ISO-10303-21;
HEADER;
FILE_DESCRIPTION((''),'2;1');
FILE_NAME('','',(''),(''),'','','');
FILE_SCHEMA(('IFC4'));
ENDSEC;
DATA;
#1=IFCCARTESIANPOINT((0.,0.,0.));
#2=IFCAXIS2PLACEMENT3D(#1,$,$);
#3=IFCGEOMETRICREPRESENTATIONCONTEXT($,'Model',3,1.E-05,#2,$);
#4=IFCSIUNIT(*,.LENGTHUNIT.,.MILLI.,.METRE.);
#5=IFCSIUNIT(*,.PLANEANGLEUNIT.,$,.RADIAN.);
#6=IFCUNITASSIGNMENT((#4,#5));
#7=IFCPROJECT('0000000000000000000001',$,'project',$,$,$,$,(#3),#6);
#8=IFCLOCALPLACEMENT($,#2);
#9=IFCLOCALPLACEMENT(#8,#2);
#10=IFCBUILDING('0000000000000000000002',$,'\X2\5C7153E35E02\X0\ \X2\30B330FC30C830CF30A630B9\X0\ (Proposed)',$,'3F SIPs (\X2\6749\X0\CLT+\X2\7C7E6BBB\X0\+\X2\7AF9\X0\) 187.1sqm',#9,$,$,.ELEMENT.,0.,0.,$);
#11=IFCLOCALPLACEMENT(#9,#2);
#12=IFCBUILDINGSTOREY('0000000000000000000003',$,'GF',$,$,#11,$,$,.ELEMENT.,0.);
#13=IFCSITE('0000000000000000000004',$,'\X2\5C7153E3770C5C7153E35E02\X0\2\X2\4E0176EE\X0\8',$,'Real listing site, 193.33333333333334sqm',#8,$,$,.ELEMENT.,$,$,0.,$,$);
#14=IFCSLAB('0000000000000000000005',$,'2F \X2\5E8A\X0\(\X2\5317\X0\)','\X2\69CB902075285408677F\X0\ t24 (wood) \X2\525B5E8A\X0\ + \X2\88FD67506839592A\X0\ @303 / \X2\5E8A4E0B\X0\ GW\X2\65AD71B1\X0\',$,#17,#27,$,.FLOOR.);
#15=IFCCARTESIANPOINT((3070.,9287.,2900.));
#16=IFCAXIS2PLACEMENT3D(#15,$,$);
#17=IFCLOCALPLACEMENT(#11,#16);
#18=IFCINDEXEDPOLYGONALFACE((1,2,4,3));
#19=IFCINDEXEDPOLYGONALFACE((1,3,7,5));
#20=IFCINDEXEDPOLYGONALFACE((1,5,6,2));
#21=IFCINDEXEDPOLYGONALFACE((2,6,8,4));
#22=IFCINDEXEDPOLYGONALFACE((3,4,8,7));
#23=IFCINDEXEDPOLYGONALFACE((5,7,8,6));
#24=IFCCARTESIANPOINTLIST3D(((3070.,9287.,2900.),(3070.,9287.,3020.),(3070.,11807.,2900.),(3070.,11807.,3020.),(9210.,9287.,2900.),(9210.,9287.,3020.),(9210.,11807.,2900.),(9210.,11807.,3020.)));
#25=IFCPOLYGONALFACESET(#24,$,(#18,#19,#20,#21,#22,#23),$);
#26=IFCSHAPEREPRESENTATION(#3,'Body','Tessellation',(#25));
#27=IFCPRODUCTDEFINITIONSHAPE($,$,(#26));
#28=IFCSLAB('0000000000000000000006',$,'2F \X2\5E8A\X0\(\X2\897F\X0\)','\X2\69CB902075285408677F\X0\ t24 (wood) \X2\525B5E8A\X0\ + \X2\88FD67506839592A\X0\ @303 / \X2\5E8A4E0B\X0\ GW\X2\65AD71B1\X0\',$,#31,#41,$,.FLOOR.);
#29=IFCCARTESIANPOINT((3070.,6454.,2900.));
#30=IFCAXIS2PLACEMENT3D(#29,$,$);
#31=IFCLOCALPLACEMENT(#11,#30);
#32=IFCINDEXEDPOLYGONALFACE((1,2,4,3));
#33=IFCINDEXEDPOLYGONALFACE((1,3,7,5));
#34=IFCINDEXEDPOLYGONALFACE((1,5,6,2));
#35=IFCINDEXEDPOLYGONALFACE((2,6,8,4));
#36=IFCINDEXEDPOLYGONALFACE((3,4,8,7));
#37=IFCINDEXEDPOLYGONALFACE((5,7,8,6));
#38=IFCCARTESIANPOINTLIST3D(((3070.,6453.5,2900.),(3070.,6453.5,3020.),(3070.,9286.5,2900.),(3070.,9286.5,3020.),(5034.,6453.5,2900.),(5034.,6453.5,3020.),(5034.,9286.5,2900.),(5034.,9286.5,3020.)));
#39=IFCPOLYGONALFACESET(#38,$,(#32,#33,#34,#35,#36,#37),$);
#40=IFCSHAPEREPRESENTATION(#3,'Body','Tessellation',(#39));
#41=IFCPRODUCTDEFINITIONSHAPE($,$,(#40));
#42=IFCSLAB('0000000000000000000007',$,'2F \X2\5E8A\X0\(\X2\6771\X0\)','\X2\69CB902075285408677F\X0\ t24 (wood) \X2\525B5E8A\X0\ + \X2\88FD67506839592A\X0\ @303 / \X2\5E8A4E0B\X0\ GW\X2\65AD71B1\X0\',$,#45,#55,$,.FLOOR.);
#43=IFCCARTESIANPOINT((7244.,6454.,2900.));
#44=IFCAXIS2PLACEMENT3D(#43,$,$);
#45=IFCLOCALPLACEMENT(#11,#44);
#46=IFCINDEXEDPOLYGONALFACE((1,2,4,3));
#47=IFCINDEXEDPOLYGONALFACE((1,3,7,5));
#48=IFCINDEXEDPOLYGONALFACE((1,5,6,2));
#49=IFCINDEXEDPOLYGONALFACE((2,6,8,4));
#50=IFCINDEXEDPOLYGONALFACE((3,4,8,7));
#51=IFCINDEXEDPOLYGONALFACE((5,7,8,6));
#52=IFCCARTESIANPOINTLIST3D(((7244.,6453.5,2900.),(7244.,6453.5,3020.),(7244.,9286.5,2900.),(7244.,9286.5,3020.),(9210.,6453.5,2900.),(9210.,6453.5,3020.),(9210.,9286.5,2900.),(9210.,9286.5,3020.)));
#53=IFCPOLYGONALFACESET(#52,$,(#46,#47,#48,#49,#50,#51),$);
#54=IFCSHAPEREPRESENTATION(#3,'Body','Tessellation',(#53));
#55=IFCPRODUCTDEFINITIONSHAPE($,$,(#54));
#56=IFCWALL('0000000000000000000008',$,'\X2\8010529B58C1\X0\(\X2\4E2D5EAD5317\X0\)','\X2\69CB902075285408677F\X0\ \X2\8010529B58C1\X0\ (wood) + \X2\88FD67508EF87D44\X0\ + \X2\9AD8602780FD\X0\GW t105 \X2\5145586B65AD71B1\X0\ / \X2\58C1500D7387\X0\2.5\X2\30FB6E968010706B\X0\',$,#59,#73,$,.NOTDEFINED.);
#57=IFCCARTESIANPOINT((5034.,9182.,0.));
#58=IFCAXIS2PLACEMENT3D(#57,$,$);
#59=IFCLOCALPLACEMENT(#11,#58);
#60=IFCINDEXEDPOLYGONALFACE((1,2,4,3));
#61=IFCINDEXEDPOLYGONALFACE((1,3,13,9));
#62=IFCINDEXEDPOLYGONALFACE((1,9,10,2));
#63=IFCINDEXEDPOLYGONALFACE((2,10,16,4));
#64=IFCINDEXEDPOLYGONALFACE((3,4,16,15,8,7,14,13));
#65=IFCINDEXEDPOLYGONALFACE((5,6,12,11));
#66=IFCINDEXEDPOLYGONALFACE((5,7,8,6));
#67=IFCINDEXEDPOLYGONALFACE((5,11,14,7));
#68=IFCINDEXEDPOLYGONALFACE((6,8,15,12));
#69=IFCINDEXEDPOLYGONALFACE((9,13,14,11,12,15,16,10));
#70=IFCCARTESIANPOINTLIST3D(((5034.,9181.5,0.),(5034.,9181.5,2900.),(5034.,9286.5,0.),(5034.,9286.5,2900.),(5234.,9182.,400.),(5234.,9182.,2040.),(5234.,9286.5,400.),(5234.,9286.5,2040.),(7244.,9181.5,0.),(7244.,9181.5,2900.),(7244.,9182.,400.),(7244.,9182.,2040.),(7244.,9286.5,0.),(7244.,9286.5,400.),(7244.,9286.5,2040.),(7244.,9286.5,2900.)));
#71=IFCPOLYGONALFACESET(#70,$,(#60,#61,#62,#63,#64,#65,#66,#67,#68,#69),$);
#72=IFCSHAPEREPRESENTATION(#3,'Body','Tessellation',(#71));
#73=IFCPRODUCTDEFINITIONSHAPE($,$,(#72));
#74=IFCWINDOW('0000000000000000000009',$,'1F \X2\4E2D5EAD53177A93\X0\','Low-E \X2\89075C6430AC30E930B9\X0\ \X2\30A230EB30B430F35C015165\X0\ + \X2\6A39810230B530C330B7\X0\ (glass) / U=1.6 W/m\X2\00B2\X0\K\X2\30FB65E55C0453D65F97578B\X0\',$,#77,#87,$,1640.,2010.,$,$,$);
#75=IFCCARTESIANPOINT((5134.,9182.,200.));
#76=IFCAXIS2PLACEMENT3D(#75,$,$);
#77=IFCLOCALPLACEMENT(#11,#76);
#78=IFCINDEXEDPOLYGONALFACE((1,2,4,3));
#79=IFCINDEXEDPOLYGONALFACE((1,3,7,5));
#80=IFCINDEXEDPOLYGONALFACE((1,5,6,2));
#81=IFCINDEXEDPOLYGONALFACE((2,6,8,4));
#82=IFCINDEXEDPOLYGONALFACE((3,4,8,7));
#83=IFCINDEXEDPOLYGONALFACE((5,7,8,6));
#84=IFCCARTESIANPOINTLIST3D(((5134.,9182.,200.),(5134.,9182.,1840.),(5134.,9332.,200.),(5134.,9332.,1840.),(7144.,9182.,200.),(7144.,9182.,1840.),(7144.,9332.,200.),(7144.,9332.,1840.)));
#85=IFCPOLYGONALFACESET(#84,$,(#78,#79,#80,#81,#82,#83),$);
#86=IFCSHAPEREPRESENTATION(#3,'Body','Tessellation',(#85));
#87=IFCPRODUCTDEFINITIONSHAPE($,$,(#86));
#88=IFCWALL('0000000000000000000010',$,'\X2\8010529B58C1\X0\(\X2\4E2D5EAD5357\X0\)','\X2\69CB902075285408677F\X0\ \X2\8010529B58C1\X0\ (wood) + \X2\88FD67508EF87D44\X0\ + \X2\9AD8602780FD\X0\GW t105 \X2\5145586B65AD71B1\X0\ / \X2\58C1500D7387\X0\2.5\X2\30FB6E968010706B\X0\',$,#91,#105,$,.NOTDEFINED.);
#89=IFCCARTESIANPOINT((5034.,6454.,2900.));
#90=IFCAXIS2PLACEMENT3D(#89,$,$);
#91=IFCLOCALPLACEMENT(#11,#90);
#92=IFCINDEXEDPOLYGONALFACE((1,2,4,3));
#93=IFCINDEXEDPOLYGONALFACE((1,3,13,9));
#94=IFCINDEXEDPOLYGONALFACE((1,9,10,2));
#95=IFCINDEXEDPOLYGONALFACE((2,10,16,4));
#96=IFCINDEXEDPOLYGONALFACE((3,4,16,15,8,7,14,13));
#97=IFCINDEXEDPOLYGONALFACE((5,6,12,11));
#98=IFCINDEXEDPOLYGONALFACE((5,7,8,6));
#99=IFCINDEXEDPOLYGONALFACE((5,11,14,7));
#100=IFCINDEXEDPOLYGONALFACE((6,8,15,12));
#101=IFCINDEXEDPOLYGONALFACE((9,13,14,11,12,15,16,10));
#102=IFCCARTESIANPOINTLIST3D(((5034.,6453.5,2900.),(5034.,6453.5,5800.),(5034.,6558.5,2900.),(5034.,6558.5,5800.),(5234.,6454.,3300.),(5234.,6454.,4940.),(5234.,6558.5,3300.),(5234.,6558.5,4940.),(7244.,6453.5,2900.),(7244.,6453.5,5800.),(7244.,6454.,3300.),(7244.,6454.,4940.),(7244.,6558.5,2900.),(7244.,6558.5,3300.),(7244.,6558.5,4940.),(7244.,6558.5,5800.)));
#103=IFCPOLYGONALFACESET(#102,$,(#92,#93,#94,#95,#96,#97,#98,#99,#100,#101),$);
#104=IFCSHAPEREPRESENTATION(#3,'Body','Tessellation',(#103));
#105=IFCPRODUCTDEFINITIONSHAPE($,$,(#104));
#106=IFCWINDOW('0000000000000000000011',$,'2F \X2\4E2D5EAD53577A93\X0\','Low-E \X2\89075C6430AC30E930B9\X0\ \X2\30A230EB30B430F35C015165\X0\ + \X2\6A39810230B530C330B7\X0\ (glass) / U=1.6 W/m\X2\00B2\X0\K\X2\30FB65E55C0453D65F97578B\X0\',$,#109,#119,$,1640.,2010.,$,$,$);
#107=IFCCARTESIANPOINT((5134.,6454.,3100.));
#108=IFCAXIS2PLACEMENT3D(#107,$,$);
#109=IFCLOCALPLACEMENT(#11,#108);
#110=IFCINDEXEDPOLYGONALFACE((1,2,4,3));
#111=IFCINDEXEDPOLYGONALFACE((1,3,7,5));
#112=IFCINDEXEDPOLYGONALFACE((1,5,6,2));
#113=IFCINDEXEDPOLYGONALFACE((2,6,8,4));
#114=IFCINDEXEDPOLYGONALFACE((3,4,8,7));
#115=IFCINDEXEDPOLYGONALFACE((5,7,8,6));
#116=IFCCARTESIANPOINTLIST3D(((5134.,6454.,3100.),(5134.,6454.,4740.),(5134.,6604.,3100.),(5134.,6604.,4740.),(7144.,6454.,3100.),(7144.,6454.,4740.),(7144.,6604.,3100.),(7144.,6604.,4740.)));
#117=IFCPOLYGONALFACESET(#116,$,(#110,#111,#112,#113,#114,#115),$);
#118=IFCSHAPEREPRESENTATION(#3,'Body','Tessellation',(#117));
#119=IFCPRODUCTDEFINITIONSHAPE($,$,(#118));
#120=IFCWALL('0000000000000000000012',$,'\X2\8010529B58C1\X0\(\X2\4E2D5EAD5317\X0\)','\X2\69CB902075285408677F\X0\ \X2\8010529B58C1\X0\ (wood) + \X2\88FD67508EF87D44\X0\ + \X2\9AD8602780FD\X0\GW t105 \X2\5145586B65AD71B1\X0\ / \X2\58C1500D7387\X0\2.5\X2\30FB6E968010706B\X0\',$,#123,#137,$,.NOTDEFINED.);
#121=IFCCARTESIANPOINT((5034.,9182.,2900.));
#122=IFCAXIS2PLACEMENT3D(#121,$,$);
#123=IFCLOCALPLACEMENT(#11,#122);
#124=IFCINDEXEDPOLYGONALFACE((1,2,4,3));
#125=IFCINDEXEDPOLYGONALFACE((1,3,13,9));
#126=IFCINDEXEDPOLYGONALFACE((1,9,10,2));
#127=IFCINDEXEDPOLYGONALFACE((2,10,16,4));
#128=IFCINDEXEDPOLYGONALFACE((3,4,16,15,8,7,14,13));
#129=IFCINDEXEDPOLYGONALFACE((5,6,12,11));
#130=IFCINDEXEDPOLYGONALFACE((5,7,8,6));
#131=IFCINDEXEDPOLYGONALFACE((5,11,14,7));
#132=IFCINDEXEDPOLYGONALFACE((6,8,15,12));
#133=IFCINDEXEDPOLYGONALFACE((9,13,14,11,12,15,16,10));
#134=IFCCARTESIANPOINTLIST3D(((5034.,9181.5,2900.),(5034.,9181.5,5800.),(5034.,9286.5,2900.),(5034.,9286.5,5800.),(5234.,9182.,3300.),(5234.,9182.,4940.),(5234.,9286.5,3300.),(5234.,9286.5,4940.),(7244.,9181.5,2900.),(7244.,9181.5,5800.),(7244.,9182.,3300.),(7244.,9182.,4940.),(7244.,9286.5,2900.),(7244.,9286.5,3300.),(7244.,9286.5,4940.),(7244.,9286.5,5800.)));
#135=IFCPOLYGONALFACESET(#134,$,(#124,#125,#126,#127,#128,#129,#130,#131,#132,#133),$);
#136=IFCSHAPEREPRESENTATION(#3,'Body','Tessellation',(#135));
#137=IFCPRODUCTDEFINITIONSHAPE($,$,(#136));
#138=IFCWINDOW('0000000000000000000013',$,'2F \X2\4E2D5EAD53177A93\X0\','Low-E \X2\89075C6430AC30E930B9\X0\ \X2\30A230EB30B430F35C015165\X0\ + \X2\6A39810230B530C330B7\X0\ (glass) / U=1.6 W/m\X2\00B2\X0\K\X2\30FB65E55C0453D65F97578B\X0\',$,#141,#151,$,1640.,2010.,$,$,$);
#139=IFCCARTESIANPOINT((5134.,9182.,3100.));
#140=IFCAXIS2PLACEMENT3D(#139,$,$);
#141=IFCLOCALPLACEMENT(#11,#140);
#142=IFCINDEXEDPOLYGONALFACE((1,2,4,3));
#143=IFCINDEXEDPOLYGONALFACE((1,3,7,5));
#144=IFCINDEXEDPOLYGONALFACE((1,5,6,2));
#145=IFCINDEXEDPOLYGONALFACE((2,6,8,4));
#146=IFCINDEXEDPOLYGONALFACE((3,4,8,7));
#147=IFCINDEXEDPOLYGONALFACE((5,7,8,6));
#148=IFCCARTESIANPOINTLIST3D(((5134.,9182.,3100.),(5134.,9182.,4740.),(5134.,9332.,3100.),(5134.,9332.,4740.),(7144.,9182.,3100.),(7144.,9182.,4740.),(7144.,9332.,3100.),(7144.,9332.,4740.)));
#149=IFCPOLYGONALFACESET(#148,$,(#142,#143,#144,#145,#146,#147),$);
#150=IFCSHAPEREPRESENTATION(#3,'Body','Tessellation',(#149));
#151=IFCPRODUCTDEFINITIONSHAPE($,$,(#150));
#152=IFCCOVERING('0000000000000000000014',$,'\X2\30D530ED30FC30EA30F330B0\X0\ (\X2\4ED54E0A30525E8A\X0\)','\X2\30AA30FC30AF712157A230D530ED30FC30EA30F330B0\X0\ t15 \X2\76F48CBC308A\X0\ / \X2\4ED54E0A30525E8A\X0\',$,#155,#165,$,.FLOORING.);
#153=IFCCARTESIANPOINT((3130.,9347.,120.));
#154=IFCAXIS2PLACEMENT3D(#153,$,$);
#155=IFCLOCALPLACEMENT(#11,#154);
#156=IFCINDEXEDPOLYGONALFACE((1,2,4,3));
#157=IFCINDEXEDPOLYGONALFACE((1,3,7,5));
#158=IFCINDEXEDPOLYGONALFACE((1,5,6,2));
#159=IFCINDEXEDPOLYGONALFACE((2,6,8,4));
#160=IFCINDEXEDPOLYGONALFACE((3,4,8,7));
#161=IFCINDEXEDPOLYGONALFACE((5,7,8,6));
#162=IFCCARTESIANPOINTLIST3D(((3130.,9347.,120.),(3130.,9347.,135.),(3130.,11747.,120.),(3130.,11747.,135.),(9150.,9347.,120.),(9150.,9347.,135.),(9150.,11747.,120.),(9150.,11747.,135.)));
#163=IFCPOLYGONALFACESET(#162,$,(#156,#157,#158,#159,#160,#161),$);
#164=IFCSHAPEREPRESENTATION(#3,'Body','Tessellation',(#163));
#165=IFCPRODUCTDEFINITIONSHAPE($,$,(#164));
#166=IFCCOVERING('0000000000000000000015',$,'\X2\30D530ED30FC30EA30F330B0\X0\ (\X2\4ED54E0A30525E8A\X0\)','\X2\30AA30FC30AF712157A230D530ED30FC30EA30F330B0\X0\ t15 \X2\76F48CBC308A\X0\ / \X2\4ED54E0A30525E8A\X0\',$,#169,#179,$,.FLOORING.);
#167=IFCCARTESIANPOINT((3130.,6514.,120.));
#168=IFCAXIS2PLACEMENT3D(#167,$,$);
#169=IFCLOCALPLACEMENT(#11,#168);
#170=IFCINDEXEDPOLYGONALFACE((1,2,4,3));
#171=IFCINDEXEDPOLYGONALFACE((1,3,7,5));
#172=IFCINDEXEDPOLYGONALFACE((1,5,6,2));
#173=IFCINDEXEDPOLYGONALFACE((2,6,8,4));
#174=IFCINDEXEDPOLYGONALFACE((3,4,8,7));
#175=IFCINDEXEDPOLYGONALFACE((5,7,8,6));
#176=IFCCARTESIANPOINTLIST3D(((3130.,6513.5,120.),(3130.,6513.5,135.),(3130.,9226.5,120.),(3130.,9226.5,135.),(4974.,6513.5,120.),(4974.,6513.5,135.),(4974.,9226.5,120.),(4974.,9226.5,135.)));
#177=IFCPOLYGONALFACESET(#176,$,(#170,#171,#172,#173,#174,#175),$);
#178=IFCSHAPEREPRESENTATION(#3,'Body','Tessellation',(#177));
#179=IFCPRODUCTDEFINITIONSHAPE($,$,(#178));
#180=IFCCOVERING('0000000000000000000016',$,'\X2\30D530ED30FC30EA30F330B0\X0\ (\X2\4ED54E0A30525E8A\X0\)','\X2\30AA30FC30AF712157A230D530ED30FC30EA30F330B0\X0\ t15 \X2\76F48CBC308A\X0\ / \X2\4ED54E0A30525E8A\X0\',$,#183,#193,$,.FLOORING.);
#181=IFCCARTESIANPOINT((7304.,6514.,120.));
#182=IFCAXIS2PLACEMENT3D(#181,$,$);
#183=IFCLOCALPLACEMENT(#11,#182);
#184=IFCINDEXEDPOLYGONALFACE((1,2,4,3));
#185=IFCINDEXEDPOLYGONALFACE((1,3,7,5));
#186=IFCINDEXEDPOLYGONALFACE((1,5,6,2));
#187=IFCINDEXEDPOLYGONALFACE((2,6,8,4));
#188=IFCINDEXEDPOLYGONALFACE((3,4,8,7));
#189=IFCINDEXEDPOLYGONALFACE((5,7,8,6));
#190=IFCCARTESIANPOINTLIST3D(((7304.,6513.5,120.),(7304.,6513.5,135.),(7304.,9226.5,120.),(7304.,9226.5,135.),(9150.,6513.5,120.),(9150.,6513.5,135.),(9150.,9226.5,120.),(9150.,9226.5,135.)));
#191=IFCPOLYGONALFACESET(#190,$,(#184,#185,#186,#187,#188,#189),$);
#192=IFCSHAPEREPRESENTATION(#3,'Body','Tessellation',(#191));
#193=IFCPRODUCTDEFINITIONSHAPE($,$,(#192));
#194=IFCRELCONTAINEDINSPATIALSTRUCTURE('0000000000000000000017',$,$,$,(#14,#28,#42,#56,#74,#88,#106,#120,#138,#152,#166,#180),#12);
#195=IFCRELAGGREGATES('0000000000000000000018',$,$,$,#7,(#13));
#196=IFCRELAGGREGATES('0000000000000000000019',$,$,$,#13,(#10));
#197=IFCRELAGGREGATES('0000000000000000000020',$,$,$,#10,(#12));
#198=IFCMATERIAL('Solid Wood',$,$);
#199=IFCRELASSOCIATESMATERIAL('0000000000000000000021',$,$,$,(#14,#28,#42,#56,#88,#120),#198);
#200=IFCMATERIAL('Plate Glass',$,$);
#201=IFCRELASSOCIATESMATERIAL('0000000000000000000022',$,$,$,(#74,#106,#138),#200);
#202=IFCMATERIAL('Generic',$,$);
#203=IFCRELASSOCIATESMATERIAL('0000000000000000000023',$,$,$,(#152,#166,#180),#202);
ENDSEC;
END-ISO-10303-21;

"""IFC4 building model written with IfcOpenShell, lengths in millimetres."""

from ifc_helpers import new_model, si_unit, frame, frame_2d, origin, place, context, project, spatial, rectangle, extrude, material, element, fill, save


model = new_model("IFC4")

# Units and contexts
model_context = context("Model", 3, precision=1e-05, world=origin())
ifc_project = project(units=[si_unit("LENGTHUNIT", "METRE", prefix="MILLI"), si_unit("PLANEANGLEUNIT", "RADIAN")], contexts=[model_context])

# Site, building, storey
site_placement = place(None, origin())
site = spatial("IfcSite", under=ifc_project, at=site_placement, Name="山口県山口市2丁目8", ObjectType="Real listing site, 193.33333333333334sqm", CompositionType="ELEMENT", RefElevation=0.0)
building_placement = place(site_placement, origin())
building = spatial("IfcBuilding", under=site, at=building_placement, Name="山口市 コートハウス (Proposed)", ObjectType="3F SIPs (杉CLT+籾殻+竹) 187.1sqm", CompositionType="ELEMENT", ElevationOfRefHeight=0.0, ElevationOfTerrain=0.0)
storey_placement = place(building_placement, origin())
storey = spatial("IfcBuildingStorey", under=building, at=storey_placement, Name="GF", CompositionType="ELEMENT", Elevation=0.0)

# Slabs
ifc_material_1 = material(Name="Solid Wood")
slab_1_placement = place(storey_placement, frame((3070.0, 9287.0, 2900.0)))
element("IfcSlab", 1, at=slab_1_placement, inside=storey, material=ifc_material_1, Name="2F 床(北)", Description="構造用合板 t24 (wood) 剛床 + 製材根太 @303 / 床下 GW断熱", PredefinedType="FLOOR", context=model_context, shape_type="SweptSolid", body=[
    extrude(rectangle(XDim=6140.0, YDim=2520.0, at=frame_2d((3070.0, 1260.0))), frame((3070.0, 9287.0, 2900.0)), (0.0, 0.0, 1.0), 120.0),
])
slab_2_placement = place(storey_placement, frame((3070.0, 6454.0, 2900.0)))
element("IfcSlab", 2, at=slab_2_placement, inside=storey, material=ifc_material_1, Name="2F 床(西)", Description="構造用合板 t24 (wood) 剛床 + 製材根太 @303 / 床下 GW断熱", PredefinedType="FLOOR", context=model_context, shape_type="SweptSolid", body=[
    extrude(rectangle(XDim=1964.0, YDim=2833.0, at=frame_2d((982.0, 1416.0))), frame((3070.0, 6454.0, 2900.0)), (0.0, 0.0, 1.0), 120.0),
])
slab_3_placement = place(storey_placement, frame((7244.0, 6454.0, 2900.0)))
element("IfcSlab", 3, at=slab_3_placement, inside=storey, material=ifc_material_1, Name="2F 床(東)", Description="構造用合板 t24 (wood) 剛床 + 製材根太 @303 / 床下 GW断熱", PredefinedType="FLOOR", context=model_context, shape_type="SweptSolid", body=[
    extrude(rectangle(XDim=1966.0, YDim=2833.0, at=frame_2d((983.0, 1416.0))), frame((7244.0, 6454.0, 2900.0)), (0.0, 0.0, 1.0), 120.0),
])

# Wall, opening, window
wall_1_placement = place(storey_placement, frame((5034.0, 9182.0, 0.0)))
wall_1 = element("IfcWall", 4, at=wall_1_placement, inside=storey, material=ifc_material_1, Name="耐力壁(中庭北)", Description="構造用合板 耐力壁 (wood) + 製材軸組 + 高性能GW t105 充填断熱 / 壁倍率2.5・準耐火", PredefinedType="NOTDEFINED", context=model_context, shape_type="SweptSolid", body=[
    extrude(rectangle(XDim=2210.0, YDim=105.0, at=frame_2d((1105.0, 52.0))), frame((5034.0, 9182.0, 0.0)), (0.0, 0.0, 1.0), 2900.0),
])
opening_1_placement = place(storey_placement, frame((5134.0, 9182.0, 200.0)))
opening_1 = element("IfcOpeningElement", 5, at=opening_1_placement, cuts=wall_1, PredefinedType="NOTDEFINED", context=model_context, shape_type="SweptSolid", body=[
    extrude(rectangle(XDim=2010.0, YDim=150.0, at=frame_2d((1005.0, 75.0))), frame((5134.0, 9182.0, 200.0)), (0.0, 0.0, 1.0), 1640.0),
])
ifc_material_2 = material(Name="Plate Glass")
window_1_placement = place(storey_placement, frame((5134.0, 9182.0, 200.0)))
window_1 = element("IfcWindow", 6, at=window_1_placement, inside=storey, material=ifc_material_2, Name="1F 中庭北窓", Description="Low-E 複層ガラス アルゴン封入 + 樹脂サッシ (glass) / U=1.6 W/m²K・日射取得型", OverallHeight=1640.0, OverallWidth=2010.0, context=model_context, shape_type="SweptSolid", body=[
    extrude(rectangle(XDim=2010.0, YDim=150.0, at=frame_2d((1005.0, 75.0))), frame((5134.0, 9182.0, 200.0)), (0.0, 0.0, 1.0), 1640.0),
])
fill(opening_1, window_1)

# Walls, openings, windows
wall_2_placement = place(storey_placement, frame((5034.0, 6454.0, 2900.0)))
wall_2 = element("IfcWall", 7, at=wall_2_placement, inside=storey, material=ifc_material_1, Name="耐力壁(中庭南)", Description="構造用合板 耐力壁 (wood) + 製材軸組 + 高性能GW t105 充填断熱 / 壁倍率2.5・準耐火", PredefinedType="NOTDEFINED", context=model_context, shape_type="SweptSolid", body=[
    extrude(rectangle(XDim=2210.0, YDim=105.0, at=frame_2d((1105.0, 52.0))), frame((5034.0, 6454.0, 2900.0)), (0.0, 0.0, 1.0), 2900.0),
])
opening_2_placement = place(storey_placement, frame((5134.0, 6454.0, 3100.0)))
opening_2 = element("IfcOpeningElement", 8, at=opening_2_placement, cuts=wall_2, PredefinedType="NOTDEFINED", context=model_context, shape_type="SweptSolid", body=[
    extrude(rectangle(XDim=2010.0, YDim=150.0, at=frame_2d((1005.0, 75.0))), frame((5134.0, 6454.0, 3100.0)), (0.0, 0.0, 1.0), 1640.0),
])
window_2_placement = place(storey_placement, frame((5134.0, 6454.0, 3100.0)))
window_2 = element("IfcWindow", 9, at=window_2_placement, inside=storey, material=ifc_material_2, Name="2F 中庭南窓", Description="Low-E 複層ガラス アルゴン封入 + 樹脂サッシ (glass) / U=1.6 W/m²K・日射取得型", OverallHeight=1640.0, OverallWidth=2010.0, context=model_context, shape_type="SweptSolid", body=[
    extrude(rectangle(XDim=2010.0, YDim=150.0, at=frame_2d((1005.0, 75.0))), frame((5134.0, 6454.0, 3100.0)), (0.0, 0.0, 1.0), 1640.0),
])
fill(opening_2, window_2)
wall_3_placement = place(storey_placement, frame((5034.0, 9182.0, 2900.0)))
wall_3 = element("IfcWall", 10, at=wall_3_placement, inside=storey, material=ifc_material_1, Name="耐力壁(中庭北)", Description="構造用合板 耐力壁 (wood) + 製材軸組 + 高性能GW t105 充填断熱 / 壁倍率2.5・準耐火", PredefinedType="NOTDEFINED", context=model_context, shape_type="SweptSolid", body=[
    extrude(rectangle(XDim=2210.0, YDim=105.0, at=frame_2d((1105.0, 52.0))), frame((5034.0, 9182.0, 2900.0)), (0.0, 0.0, 1.0), 2900.0),
])
opening_3_placement = place(storey_placement, frame((5134.0, 9182.0, 3100.0)))
opening_3 = element("IfcOpeningElement", 11, at=opening_3_placement, cuts=wall_3, PredefinedType="NOTDEFINED", context=model_context, shape_type="SweptSolid", body=[
    extrude(rectangle(XDim=2010.0, YDim=150.0, at=frame_2d((1005.0, 75.0))), frame((5134.0, 9182.0, 3100.0)), (0.0, 0.0, 1.0), 1640.0),
])
window_3_placement = place(storey_placement, frame((5134.0, 9182.0, 3100.0)))
window_3 = element("IfcWindow", 12, at=window_3_placement, inside=storey, material=ifc_material_2, Name="2F 中庭北窓", Description="Low-E 複層ガラス アルゴン封入 + 樹脂サッシ (glass) / U=1.6 W/m²K・日射取得型", OverallHeight=1640.0, OverallWidth=2010.0, context=model_context, shape_type="SweptSolid", body=[
    extrude(rectangle(XDim=2010.0, YDim=150.0, at=frame_2d((1005.0, 75.0))), frame((5134.0, 9182.0, 3100.0)), (0.0, 0.0, 1.0), 1640.0),
])
fill(opening_3, window_3)

# Coverings
ifc_material_3 = material(Name="Generic")
covering_1_placement = place(storey_placement, frame((3130.0, 9347.0, 120.0)))
element("IfcCovering", 13, at=covering_1_placement, inside=storey, material=ifc_material_3, Name="フローリング (仕上げ床)", Description="オーク無垢フローリング t15 直貼り / 仕上げ床", PredefinedType="FLOORING", context=model_context, shape_type="SweptSolid", body=[
    extrude(rectangle(XDim=6020.0, YDim=2400.0, at=frame_2d((3010.0, 1200.0))), frame((3130.0, 9347.0, 120.0)), (0.0, 0.0, 1.0), 15.0),
])
covering_2_placement = place(storey_placement, frame((3130.0, 6514.0, 120.0)))
element("IfcCovering", 14, at=covering_2_placement, inside=storey, material=ifc_material_3, Name="フローリング (仕上げ床)", Description="オーク無垢フローリング t15 直貼り / 仕上げ床", PredefinedType="FLOORING", context=model_context, shape_type="SweptSolid", body=[
    extrude(rectangle(XDim=1844.0, YDim=2713.0, at=frame_2d((922.0, 1356.0))), frame((3130.0, 6514.0, 120.0)), (0.0, 0.0, 1.0), 15.0),
])
covering_3_placement = place(storey_placement, frame((7304.0, 6514.0, 120.0)))
element("IfcCovering", 15, at=covering_3_placement, inside=storey, material=ifc_material_3, Name="フローリング (仕上げ床)", Description="オーク無垢フローリング t15 直貼り / 仕上げ床", PredefinedType="FLOORING", context=model_context, shape_type="SweptSolid", body=[
    extrude(rectangle(XDim=1846.0, YDim=2713.0, at=frame_2d((923.0, 1356.0))), frame((7304.0, 6514.0, 120.0)), (0.0, 0.0, 1.0), 15.0),
])

save(model, "model.ifc")
